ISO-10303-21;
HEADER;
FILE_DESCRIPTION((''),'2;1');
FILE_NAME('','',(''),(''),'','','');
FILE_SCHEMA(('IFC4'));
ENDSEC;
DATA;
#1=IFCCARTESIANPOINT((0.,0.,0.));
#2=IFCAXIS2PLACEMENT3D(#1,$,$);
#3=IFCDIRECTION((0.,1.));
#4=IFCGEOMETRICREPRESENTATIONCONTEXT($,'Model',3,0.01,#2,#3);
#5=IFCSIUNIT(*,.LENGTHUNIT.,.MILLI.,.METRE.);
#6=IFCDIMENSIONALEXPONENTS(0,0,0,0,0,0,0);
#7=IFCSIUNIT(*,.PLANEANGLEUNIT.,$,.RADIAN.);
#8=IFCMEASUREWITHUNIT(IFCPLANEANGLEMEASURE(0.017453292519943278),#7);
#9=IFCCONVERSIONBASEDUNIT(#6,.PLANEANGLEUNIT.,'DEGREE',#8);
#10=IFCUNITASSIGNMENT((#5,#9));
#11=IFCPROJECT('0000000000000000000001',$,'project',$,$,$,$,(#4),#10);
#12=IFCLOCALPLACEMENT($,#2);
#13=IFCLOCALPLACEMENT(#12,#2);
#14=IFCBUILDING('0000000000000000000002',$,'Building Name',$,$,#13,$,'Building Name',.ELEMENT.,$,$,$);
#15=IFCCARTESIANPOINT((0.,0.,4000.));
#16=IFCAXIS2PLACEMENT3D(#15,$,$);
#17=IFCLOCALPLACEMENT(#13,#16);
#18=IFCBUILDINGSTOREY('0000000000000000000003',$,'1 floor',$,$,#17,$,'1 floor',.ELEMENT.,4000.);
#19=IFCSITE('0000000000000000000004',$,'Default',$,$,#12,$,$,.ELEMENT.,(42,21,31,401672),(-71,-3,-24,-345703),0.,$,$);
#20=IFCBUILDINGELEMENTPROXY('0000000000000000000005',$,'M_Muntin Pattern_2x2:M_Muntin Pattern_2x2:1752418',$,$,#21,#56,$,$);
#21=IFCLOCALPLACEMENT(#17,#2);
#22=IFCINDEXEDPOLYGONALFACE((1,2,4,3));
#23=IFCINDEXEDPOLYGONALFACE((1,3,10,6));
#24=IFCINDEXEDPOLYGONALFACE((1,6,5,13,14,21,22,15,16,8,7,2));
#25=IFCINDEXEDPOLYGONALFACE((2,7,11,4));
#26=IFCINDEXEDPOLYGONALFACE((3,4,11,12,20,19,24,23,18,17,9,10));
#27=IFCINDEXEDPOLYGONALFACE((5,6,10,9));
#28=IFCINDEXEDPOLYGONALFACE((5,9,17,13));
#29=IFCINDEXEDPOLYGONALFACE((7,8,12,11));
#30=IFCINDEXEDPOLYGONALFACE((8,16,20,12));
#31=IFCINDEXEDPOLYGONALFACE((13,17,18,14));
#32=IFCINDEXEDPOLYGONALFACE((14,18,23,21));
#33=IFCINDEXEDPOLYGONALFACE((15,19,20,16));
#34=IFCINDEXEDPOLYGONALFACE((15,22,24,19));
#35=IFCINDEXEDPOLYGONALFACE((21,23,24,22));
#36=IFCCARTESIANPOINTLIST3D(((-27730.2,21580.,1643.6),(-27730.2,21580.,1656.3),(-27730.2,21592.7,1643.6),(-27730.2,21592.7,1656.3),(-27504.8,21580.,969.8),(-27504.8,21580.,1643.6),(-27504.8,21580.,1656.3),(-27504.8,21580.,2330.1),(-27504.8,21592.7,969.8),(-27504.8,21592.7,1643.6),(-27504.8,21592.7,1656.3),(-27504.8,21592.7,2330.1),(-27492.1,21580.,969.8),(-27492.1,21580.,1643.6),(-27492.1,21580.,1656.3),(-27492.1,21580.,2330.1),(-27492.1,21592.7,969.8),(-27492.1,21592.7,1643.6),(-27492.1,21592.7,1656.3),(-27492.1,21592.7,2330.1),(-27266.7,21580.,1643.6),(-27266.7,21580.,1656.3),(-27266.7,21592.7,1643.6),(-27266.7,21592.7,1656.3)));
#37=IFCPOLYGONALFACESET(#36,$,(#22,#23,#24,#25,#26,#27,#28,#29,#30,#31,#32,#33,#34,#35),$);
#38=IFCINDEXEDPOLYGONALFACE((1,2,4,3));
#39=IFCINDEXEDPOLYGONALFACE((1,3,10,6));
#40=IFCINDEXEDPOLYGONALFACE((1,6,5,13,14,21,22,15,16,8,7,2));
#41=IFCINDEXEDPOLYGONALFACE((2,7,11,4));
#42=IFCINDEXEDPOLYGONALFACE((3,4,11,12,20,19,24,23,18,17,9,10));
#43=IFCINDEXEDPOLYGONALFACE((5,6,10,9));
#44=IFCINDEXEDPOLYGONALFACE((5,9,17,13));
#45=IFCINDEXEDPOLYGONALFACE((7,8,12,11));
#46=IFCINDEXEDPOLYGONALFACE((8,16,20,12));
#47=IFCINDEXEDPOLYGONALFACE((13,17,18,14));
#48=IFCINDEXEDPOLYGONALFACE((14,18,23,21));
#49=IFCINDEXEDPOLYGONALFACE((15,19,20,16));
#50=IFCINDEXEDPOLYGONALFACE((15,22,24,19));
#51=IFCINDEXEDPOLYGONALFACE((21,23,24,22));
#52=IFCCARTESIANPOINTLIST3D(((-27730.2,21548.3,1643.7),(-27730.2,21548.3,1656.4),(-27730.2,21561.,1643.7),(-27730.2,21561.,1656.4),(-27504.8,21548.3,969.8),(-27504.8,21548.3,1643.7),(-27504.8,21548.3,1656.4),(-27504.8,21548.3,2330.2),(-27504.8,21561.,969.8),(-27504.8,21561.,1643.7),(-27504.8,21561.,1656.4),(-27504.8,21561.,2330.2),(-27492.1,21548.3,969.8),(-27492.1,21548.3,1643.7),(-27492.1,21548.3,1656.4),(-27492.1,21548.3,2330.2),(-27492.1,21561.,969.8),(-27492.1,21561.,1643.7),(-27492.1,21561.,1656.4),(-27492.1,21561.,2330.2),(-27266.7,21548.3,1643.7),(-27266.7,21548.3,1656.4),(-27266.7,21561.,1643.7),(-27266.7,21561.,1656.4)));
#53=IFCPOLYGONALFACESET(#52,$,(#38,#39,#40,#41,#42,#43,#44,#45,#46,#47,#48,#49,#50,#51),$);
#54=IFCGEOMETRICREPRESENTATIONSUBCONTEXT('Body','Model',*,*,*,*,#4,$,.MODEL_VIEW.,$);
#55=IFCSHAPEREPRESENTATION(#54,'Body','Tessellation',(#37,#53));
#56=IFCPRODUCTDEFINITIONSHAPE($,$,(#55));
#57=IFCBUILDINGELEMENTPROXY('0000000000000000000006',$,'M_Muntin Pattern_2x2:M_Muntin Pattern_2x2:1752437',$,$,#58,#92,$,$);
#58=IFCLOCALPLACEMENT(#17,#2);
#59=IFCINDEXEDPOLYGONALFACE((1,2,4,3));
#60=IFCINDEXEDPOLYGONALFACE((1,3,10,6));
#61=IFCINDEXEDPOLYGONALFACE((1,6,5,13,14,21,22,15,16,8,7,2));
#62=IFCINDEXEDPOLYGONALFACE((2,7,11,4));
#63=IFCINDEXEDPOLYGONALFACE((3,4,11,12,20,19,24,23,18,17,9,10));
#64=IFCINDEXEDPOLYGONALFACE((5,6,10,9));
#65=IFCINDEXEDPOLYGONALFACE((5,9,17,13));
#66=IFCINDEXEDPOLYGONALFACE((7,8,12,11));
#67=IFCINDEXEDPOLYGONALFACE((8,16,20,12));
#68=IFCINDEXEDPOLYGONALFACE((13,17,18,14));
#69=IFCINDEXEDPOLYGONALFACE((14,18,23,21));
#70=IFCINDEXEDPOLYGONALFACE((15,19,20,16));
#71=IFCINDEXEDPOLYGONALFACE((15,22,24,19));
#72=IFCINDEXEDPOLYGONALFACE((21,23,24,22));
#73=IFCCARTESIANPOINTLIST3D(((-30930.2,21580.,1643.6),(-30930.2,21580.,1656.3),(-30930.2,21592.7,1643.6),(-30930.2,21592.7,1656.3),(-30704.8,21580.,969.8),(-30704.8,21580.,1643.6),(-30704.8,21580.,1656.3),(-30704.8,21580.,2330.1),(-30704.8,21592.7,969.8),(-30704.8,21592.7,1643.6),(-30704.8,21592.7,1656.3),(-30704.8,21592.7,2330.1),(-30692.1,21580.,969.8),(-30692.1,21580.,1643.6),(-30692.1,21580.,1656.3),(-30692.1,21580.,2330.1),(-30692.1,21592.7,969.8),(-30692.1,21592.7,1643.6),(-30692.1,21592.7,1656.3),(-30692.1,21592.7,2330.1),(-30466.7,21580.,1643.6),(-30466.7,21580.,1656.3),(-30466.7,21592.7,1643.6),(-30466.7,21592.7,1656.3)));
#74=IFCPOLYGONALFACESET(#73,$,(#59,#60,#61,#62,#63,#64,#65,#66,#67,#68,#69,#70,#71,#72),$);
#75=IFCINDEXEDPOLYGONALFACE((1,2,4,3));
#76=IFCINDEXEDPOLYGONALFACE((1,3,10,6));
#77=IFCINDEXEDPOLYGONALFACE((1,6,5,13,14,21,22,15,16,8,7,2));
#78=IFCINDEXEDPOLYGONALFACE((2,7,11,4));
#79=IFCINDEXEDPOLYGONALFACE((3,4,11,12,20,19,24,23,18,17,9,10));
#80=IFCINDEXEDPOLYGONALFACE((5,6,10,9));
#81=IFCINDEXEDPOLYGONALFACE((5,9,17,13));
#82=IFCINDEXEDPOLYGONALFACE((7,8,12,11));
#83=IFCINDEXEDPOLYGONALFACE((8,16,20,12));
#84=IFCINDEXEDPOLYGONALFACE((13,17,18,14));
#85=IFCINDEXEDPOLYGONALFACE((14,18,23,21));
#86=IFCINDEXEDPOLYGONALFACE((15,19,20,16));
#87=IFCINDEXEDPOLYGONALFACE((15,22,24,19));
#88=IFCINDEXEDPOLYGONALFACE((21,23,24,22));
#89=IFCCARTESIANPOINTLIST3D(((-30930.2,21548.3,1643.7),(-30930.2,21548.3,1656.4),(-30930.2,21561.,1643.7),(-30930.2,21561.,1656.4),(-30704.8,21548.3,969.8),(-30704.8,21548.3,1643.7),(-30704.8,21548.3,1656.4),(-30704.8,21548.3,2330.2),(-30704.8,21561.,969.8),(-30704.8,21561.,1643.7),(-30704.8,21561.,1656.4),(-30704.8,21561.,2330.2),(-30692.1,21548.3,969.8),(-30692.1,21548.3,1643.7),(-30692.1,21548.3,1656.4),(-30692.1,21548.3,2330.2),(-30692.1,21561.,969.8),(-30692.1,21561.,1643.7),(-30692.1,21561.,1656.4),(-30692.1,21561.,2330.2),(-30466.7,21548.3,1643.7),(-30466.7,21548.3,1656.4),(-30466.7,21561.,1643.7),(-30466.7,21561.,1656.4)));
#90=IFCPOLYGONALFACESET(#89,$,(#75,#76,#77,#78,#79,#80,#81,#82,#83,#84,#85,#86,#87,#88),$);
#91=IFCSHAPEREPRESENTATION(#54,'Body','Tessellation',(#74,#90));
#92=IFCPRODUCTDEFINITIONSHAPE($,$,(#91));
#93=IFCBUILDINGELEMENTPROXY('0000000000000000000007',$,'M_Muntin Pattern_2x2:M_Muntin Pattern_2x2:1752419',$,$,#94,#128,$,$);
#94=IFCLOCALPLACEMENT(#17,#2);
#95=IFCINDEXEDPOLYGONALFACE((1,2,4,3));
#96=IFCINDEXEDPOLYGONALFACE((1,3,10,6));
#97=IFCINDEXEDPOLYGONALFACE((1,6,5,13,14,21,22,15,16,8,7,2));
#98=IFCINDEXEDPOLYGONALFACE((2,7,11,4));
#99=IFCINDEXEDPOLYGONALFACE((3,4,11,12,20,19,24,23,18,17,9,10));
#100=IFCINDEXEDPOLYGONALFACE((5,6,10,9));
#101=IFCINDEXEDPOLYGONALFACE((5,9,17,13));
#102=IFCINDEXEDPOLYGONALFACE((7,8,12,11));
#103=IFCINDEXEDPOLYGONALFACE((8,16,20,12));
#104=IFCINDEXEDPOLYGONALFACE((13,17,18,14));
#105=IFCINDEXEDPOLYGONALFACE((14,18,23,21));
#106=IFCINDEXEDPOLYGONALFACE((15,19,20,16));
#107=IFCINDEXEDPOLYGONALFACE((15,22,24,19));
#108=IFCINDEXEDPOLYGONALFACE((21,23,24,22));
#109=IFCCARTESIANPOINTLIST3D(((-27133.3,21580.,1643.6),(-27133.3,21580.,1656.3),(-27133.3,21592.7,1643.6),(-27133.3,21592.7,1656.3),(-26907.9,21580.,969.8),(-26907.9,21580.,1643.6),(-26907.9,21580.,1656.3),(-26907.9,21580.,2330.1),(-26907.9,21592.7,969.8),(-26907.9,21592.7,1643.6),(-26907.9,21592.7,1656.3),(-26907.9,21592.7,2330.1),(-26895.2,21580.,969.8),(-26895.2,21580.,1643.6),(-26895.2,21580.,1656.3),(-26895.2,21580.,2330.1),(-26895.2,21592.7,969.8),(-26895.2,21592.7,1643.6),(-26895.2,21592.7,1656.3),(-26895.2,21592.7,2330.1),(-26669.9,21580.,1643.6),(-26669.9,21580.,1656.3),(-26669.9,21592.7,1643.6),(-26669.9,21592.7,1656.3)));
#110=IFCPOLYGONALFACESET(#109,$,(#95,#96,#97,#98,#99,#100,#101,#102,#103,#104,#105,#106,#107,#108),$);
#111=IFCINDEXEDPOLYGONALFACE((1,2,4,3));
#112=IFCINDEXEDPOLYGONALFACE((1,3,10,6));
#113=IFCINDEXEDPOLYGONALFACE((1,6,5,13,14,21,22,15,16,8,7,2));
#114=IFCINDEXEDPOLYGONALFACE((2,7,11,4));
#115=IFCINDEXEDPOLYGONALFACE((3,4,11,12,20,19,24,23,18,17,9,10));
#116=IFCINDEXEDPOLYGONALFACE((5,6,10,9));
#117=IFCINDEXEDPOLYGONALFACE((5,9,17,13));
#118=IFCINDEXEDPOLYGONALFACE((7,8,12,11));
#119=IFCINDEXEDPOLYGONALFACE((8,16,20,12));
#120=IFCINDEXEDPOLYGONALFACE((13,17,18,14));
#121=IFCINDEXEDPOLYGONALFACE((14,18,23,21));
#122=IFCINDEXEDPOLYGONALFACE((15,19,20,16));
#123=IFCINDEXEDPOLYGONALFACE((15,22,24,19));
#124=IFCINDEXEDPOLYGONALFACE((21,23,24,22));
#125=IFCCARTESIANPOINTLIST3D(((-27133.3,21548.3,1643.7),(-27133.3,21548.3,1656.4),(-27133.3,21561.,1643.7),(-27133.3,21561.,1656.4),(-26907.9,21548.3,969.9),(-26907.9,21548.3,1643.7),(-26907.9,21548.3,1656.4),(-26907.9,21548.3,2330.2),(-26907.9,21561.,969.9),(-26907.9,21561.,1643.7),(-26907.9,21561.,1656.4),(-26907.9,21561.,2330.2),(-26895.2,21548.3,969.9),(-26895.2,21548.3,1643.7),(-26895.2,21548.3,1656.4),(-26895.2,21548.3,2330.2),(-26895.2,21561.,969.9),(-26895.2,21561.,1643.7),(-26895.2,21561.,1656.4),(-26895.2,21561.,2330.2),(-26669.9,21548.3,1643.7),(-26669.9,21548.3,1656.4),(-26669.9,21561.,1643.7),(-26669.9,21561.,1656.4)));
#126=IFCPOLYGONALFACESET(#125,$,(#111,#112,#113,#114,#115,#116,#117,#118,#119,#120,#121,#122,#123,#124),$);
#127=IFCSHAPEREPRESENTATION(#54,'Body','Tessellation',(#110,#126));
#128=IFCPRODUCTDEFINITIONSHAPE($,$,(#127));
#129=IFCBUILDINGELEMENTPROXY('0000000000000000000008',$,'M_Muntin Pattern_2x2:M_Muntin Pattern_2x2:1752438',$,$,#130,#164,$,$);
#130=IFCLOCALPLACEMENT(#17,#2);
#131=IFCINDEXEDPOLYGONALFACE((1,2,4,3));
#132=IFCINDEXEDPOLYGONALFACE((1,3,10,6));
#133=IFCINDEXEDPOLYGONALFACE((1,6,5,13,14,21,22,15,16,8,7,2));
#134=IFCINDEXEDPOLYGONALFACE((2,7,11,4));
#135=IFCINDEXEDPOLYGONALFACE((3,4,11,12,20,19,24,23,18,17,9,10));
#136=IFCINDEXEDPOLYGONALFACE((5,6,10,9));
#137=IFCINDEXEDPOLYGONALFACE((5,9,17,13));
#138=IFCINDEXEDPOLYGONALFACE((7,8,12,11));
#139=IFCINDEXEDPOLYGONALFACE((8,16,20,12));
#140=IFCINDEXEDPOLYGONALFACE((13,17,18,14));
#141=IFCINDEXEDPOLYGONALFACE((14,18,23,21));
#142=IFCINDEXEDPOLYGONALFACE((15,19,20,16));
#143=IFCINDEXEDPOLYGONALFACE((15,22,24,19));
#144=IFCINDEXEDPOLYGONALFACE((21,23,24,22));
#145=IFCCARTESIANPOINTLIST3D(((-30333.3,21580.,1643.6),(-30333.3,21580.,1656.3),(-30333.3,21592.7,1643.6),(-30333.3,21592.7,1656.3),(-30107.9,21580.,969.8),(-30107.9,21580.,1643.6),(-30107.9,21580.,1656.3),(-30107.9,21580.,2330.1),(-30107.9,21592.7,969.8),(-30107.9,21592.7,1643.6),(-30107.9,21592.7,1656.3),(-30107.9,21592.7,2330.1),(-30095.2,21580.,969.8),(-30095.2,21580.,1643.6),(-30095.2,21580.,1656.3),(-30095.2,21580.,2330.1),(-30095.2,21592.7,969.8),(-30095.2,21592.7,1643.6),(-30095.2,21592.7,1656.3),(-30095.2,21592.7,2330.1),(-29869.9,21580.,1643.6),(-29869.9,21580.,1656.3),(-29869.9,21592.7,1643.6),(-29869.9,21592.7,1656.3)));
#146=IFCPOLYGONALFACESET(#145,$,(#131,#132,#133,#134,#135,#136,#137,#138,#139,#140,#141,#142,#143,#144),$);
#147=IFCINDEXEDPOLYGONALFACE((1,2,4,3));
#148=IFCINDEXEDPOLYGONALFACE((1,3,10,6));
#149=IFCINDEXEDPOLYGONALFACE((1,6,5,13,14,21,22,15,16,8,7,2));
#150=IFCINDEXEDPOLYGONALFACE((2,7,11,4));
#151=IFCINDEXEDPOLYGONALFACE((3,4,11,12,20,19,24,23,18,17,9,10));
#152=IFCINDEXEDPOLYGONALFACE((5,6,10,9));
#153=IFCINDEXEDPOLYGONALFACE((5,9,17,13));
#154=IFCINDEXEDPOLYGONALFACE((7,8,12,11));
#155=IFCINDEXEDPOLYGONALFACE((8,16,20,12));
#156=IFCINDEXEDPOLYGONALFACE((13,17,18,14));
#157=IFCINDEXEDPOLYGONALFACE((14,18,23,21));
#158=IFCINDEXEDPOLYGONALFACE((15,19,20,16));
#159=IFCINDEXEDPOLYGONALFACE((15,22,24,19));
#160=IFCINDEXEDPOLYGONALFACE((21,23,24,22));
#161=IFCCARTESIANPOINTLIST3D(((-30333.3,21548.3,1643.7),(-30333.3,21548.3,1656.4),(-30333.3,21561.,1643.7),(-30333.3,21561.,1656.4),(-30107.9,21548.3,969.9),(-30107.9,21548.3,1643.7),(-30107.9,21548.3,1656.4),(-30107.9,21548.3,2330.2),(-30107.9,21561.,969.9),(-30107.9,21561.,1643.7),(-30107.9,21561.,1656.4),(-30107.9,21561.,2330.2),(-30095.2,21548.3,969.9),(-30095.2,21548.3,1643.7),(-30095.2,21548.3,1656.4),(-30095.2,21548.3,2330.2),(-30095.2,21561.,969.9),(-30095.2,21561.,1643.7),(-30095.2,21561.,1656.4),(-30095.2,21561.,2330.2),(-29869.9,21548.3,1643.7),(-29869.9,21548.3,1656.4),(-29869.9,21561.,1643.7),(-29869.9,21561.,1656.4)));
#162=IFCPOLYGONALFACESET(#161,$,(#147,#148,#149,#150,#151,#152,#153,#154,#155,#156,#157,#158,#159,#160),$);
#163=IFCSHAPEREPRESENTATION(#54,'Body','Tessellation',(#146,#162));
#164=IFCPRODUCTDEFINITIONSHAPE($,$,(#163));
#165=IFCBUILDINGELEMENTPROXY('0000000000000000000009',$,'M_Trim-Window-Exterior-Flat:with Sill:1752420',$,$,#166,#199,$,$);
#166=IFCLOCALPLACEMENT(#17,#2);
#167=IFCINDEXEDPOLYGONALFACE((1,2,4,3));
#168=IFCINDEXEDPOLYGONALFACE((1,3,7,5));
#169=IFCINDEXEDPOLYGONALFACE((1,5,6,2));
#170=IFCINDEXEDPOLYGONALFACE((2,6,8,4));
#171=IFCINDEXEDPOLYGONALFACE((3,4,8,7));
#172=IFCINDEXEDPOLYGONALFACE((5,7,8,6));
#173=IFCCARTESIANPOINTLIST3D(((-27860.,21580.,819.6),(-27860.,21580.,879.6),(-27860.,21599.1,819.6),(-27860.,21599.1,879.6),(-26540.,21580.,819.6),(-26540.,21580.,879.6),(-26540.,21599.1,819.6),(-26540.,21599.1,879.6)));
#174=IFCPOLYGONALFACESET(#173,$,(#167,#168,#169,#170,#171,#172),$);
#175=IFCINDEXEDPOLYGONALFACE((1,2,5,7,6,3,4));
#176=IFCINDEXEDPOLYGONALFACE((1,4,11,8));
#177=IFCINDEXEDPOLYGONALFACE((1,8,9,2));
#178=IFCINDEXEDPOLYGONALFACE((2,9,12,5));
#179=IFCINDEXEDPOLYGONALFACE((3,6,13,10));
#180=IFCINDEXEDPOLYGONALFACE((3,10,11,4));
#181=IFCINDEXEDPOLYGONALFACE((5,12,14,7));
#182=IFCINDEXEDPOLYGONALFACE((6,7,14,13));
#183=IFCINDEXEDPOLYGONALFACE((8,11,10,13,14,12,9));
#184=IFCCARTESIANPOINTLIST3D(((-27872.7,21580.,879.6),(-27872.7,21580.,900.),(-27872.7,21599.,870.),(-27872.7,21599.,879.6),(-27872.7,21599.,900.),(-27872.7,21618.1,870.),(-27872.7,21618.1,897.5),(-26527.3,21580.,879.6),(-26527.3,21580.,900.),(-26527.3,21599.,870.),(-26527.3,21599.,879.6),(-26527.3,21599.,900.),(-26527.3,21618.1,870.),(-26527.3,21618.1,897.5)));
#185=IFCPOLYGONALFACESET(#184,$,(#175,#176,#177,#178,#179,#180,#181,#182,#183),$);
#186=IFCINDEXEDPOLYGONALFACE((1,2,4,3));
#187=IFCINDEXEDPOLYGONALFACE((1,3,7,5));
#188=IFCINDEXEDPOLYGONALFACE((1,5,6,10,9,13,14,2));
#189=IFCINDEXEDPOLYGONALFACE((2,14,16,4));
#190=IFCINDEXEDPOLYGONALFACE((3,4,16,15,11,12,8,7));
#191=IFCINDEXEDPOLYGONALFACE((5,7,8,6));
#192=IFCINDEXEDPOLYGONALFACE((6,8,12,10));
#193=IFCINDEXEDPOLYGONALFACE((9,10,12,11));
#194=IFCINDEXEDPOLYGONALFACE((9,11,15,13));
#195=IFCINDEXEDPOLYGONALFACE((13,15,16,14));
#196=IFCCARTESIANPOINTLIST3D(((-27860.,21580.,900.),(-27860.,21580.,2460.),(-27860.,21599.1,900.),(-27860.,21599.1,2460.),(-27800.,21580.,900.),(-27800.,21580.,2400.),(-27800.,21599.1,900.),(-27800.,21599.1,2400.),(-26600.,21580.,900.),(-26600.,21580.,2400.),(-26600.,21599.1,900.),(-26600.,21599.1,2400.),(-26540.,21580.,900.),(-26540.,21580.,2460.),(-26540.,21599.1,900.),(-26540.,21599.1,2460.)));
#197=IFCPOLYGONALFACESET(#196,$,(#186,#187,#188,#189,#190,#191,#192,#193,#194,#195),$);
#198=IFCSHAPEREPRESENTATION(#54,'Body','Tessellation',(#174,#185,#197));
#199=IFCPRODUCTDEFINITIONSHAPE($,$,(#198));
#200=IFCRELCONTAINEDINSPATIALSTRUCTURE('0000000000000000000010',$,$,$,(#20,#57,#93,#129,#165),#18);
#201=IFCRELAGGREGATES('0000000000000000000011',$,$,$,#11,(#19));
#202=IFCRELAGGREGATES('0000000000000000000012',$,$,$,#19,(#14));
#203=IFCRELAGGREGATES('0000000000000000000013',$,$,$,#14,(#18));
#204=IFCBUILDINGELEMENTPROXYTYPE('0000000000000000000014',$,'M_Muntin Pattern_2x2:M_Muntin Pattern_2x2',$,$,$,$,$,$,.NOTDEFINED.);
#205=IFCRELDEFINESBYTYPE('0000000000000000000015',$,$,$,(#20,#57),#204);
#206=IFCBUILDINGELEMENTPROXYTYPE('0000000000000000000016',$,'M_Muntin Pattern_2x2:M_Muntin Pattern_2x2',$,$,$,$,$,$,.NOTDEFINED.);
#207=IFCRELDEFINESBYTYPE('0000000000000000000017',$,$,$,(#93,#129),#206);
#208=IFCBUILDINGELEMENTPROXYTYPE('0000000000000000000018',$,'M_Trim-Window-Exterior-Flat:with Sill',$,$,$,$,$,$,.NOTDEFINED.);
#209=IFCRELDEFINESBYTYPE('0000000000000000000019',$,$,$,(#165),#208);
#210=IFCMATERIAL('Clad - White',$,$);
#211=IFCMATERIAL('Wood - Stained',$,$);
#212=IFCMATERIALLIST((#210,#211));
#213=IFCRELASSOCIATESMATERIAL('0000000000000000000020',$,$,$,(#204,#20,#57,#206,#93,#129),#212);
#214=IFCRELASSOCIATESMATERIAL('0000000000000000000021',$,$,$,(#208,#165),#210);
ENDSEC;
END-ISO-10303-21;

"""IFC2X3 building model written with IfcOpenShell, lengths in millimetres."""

from ifc_helpers import new_model, entity, si_unit, converted_unit, direction, frame, frame_2d, origin, place, context, subcontext, project, spatial, polyline, rectangle, outline, extrude, source, transform, mapped, material, material_list, type_object, type_shapes, element, save


model = new_model("IFC2X3")

# Units and contexts
model_context = context("Model", 3, precision=0.01, world=origin(), true_north=direction((0.0, 1.0)))
body_context = subcontext(model_context, "Body", "Model", "MODEL_VIEW")
ifc_project = project(units=[si_unit("LENGTHUNIT", "METRE", prefix="MILLI"), converted_unit("PLANEANGLEUNIT", "DEGREE", entity("IfcPlaneAngleMeasure", 0.017453292519943278), si_unit("PLANEANGLEUNIT", "RADIAN"), dimensions=[0, 0, 0, 0, 0, 0, 0])], contexts=[model_context])

# Site, building, storey
site_placement = place(None, origin())
site = spatial("IfcSite", under=ifc_project, at=site_placement, Name="Default", CompositionType="ELEMENT", RefLatitude=(42, 21, 31, 401672), RefLongitude=(-71, -3, -24, -345703), RefElevation=0.0)
building_placement = place(site_placement, origin())
building = spatial("IfcBuilding", under=site, at=building_placement, Name="Building Name", LongName="Building Name", CompositionType="ELEMENT")
storey_placement = place(building_placement, frame((0.0, 0.0, 4000.0)))
storey = spatial("IfcBuildingStorey", under=building, at=storey_placement, Name="1 floor", LongName="1 floor", CompositionType="ELEMENT", Elevation=4000.0)

# Building element proxies
ifc_material_1 = material(Name="Clad - White")
ifc_material_2 = material(Name="Wood - Stained")
ifc_material_list = material_list([ifc_material_1, ifc_material_2])
building_element_proxy_type_1 = type_object("IfcBuildingElementProxyType", Name="M_Muntin Pattern_2x2:M_Muntin Pattern_2x2", PredefinedType="NOTDEFINED", material=ifc_material_list)
shared_shape_1 = source(origin(), body_context, "Body", "SweptSolid", [
    extrude(outline(polyline([(6.4, -6.4), (680.1, -6.4), (680.1, 6.3), (6.4, 6.3), (6.4, 231.7), (-6.3, 231.7), (-6.3, 6.3), (-680.2, 6.3), (-680.2, -6.4), (-6.3, -6.4), (-6.3, -231.7), (6.4, -231.7), (6.4, -6.4)])), frame((0.0, 9.5, 680.1), z_axis=(0.0, 1.0, 0.0), x_axis=(0.0, 0.0, 1.0)), (0.0, 0.0, 1.0), 12.7),
    extrude(outline(polyline([(6.4, -6.4), (680.2, -6.4), (680.2, 6.3), (6.4, 6.3), (6.4, 231.7), (-6.3, 231.7), (-6.3, 6.3), (-680.2, 6.3), (-680.2, -6.4), (-6.3, -6.4), (-6.3, -231.7), (6.4, -231.7), (6.4, -6.4)])), frame((0.0, -22.2, 680.2), z_axis=(0.0, 1.0, 0.0), x_axis=(0.0, 0.0, 1.0)), (0.0, 0.0, 1.0), 12.7),
])
type_shapes(building_element_proxy_type_1, [shared_shape_1])
for number, where, name in (
    (1, (-27498.4, 21570.5, 969.8), "M_Muntin Pattern_2x2:M_Muntin Pattern_2x2:1752418"),
    (2, (-30698.4, 21570.5, 969.8), "M_Muntin Pattern_2x2:M_Muntin Pattern_2x2:1752437"),
):
    element("IfcBuildingElementProxy", number, at=place(storey_placement, frame(where)), inside=storey, type_object=building_element_proxy_type_1, material=ifc_material_list, Name=name, context=body_context, shape_type="MappedRepresentation", body=[
        mapped(shared_shape_1, transform((0.0, 0.0, 0.0), scale=1.0)),
    ])
building_element_proxy_type_2 = type_object("IfcBuildingElementProxyType", Name="M_Muntin Pattern_2x2:M_Muntin Pattern_2x2", PredefinedType="NOTDEFINED", material=ifc_material_list)
shared_shape_2 = source(origin(), body_context, "Body", "SweptSolid", [
    extrude(outline(polyline([(6.4, -6.4), (680.1, -6.4), (680.1, 6.3), (6.4, 6.3), (6.4, 231.7), (-6.3, 231.7), (-6.3, 6.3), (-680.2, 6.3), (-680.2, -6.4), (-6.3, -6.4), (-6.3, -231.7), (6.4, -231.7), (6.4, -6.4)])), frame((0.0, -22.2, 680.1), z_axis=(0.0, 1.0, 0.0), x_axis=(0.0, 0.0, 1.0)), (0.0, 0.0, 1.0), 12.7),
    extrude(outline(polyline([(6.4, -6.4), (680.2, -6.4), (680.2, 6.3), (6.4, 6.3), (6.4, 231.7), (-6.3, 231.7), (-6.3, 6.3), (-680.2, 6.3), (-680.2, -6.4), (-6.3, -6.4), (-6.3, -231.7), (6.4, -231.7), (6.4, -6.4)])), frame((0.0, 9.5, 680.2), z_axis=(0.0, 1.0, 0.0), x_axis=(0.0, 0.0, 1.0)), (0.0, 0.0, 1.0), 12.7),
])
type_shapes(building_element_proxy_type_2, [shared_shape_2])
for number, where, z_axis, x_axis, name in (
    (3, (-26901.6, 21570.5, 969.9), (0.0, 0.0, 1.0), (-1.0, 0.0, 0.0), "M_Muntin Pattern_2x2:M_Muntin Pattern_2x2:1752419"),
    (4, (-30101.6, 21570.5, 969.9), (0.0, 0.0, 1.0), (-1.0, 0.0, 0.0), "M_Muntin Pattern_2x2:M_Muntin Pattern_2x2:1752438"),
):
    element("IfcBuildingElementProxy", number, at=place(storey_placement, frame(where, z_axis=z_axis, x_axis=x_axis)), inside=storey, type_object=building_element_proxy_type_2, material=ifc_material_list, Name=name, context=body_context, shape_type="MappedRepresentation", body=[
        mapped(shared_shape_2, transform((0.0, 0.0, 0.0), scale=1.0)),
    ])
building_element_proxy_type_3 = type_object("IfcBuildingElementProxyType", Name="M_Trim-Window-Exterior-Flat:with Sill", PredefinedType="NOTDEFINED", material=ifc_material_1)
shared_shape_3 = source(origin(), body_context, "Body", "SweptSolid", [
    extrude(rectangle(XDim=1320.0, YDim=60.0, at=frame_2d((0.0, 0.0), x_axis=(1.0, 0.0))), frame((0.0, -1550.4, 0.0), z_axis=(0.0, 0.0, 1.0), x_axis=(-1.0, 0.0, 0.0)), (0.0, 0.0, 1.0), 19.0),
    extrude(outline(polyline([(-19.0, -15.2), (0.0, -15.2), (0.0, -5.7), (19.0, -5.7), (19.0, 14.8), (0.0, 14.8), (-19.0, 12.3), (-19.0, -15.2)])), frame((-672.7, -1514.8, 19.0), z_axis=(1.0, 0.0, 0.0), x_axis=(0.0, 0.0, -1.0)), (0.0, 0.0, 1.0), 1345.4),
    extrude(outline(polyline([(-795.0, -660.0), (765.0, -660.0), (765.0, -600.0), (-735.0, -600.0), (-735.0, 600.0), (765.0, 600.0), (765.0, 660.0), (-795.0, 660.0), (-795.0, -660.0)])), frame((0.0, -735.0, 0.0), z_axis=(0.0, 0.0, 1.0), x_axis=(0.0, -1.0, 0.0)), (0.0, 0.0, 1.0), 19.0),
])
type_shapes(building_element_proxy_type_3, [shared_shape_3])
for number, where, z_axis, x_axis, name in (
    (5, (-27200.0, 21580.0, 2400.0), (0.0, 1.0, 0.0), (-1.0, 0.0, 0.0), "M_Trim-Window-Exterior-Flat:with Sill:1752420"),
):
    element("IfcBuildingElementProxy", number, at=place(storey_placement, frame(where, z_axis=z_axis, x_axis=x_axis)), inside=storey, type_object=building_element_proxy_type_3, material=ifc_material_1, Name=name, context=body_context, shape_type="MappedRepresentation", body=[
        mapped(shared_shape_3, transform((0.0, 0.0, 0.0), scale=1.0)),
    ])

save(model, "model.ifc")
